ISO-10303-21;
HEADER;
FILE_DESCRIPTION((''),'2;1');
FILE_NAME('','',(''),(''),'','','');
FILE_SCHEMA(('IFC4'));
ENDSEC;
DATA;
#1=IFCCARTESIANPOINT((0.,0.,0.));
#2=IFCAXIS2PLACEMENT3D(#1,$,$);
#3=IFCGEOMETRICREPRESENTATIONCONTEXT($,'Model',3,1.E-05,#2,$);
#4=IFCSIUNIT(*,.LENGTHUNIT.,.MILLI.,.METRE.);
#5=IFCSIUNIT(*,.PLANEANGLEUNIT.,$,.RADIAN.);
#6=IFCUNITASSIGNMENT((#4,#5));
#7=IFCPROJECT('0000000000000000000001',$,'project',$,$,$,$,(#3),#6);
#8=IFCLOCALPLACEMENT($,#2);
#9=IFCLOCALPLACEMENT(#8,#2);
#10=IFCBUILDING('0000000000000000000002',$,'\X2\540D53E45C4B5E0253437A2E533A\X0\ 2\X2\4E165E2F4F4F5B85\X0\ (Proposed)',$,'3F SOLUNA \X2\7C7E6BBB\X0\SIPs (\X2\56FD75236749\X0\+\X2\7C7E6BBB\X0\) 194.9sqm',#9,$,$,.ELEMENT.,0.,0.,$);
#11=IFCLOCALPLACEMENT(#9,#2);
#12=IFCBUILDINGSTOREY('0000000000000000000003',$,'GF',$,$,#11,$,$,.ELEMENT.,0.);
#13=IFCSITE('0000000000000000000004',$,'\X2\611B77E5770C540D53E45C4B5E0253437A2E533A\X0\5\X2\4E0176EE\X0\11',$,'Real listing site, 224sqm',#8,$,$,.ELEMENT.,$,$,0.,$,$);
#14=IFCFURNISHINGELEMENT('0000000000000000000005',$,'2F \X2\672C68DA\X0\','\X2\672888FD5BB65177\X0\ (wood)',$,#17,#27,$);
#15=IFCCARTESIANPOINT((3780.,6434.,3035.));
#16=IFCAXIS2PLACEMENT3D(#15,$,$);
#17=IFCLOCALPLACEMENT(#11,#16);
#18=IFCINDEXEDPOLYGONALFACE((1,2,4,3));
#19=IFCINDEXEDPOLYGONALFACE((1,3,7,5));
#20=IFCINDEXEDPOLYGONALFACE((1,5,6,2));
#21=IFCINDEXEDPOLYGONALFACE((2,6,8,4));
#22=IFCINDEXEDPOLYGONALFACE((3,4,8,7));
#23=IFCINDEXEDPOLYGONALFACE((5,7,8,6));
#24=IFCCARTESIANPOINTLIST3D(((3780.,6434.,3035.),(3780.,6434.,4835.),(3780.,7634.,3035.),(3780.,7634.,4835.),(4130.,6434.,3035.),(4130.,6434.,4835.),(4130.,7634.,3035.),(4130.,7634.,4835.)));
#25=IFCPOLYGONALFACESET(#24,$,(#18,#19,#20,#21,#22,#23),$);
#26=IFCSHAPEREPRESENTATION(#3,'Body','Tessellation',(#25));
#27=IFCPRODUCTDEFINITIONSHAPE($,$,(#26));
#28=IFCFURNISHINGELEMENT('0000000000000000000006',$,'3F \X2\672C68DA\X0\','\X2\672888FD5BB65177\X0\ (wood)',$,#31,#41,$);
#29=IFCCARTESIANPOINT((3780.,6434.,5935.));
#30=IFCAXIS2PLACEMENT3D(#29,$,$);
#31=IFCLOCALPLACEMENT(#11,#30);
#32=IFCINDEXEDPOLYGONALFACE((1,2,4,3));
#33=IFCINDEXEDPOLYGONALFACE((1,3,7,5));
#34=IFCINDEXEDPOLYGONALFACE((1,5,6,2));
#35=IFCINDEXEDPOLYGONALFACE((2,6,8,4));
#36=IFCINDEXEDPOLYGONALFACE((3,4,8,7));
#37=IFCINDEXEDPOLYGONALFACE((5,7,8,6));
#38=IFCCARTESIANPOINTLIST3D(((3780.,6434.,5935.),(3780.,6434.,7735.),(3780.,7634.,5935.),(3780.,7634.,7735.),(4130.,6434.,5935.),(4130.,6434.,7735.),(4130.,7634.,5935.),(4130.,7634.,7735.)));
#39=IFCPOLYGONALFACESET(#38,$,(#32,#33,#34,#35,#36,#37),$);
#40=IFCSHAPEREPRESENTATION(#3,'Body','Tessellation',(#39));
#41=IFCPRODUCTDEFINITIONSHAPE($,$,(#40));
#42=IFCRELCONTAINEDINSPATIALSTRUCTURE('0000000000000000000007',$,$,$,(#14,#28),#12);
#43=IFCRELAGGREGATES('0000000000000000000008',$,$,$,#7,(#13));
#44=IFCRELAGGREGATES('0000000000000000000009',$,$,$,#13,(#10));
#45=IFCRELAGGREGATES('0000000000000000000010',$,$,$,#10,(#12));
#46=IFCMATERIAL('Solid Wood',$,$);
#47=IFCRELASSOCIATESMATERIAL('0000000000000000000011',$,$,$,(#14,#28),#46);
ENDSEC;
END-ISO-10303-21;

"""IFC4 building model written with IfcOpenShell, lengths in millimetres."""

from ifc_helpers import new_model, si_unit, frame, frame_2d, origin, place, context, project, spatial, rectangle, extrude, material, element, save


model = new_model("IFC4")

# Units and contexts
model_context = context("Model", 3, precision=1e-05, world=origin())
ifc_project = project(units=[si_unit("LENGTHUNIT", "METRE", prefix="MILLI"), si_unit("PLANEANGLEUNIT", "RADIAN")], contexts=[model_context])

# Site, building, storey
site_placement = place(None, origin())
site = spatial("IfcSite", under=ifc_project, at=site_placement, Name="愛知県名古屋市千種区5丁目11", ObjectType="Real listing site, 224sqm", CompositionType="ELEMENT", RefElevation=0.0)
building_placement = place(site_placement, origin())
building = spatial("IfcBuilding", under=site, at=building_placement, Name="名古屋市千種区 2世帯住宅 (Proposed)", ObjectType="3F SOLUNA 籾殻SIPs (国産杉+籾殻) 194.9sqm", CompositionType="ELEMENT", ElevationOfRefHeight=0.0, ElevationOfTerrain=0.0)
storey_placement = place(building_placement, origin())
storey = spatial("IfcBuildingStorey", under=building, at=storey_placement, Name="GF", CompositionType="ELEMENT", Elevation=0.0)

# Shared definitions
ifc_material_1 = material(Name="Solid Wood")

# Furnishing elements
furnishing_1_placement = place(storey_placement, frame((3780.0, 6434.0, 3035.0)))
element("IfcFurnishingElement", 1, at=furnishing_1_placement, inside=storey, material=ifc_material_1, Name="2F 本棚", Description="木製家具 (wood)", context=model_context, shape_type="SweptSolid", body=[
    extrude(rectangle(XDim=350.0, YDim=1200.0, at=frame_2d((175.0, 600.0))), frame((3780.0, 6434.0, 3035.0)), (0.0, 0.0, 1.0), 1800.0),
])
furnishing_2_placement = place(storey_placement, frame((3780.0, 6434.0, 5935.0)))
element("IfcFurnishingElement", 2, at=furnishing_2_placement, inside=storey, material=ifc_material_1, Name="3F 本棚", Description="木製家具 (wood)", context=model_context, shape_type="SweptSolid", body=[
    extrude(rectangle(XDim=350.0, YDim=1200.0, at=frame_2d((175.0, 600.0))), frame((3780.0, 6434.0, 5935.0)), (0.0, 0.0, 1.0), 1800.0),
])

save(model, "model.ifc")
